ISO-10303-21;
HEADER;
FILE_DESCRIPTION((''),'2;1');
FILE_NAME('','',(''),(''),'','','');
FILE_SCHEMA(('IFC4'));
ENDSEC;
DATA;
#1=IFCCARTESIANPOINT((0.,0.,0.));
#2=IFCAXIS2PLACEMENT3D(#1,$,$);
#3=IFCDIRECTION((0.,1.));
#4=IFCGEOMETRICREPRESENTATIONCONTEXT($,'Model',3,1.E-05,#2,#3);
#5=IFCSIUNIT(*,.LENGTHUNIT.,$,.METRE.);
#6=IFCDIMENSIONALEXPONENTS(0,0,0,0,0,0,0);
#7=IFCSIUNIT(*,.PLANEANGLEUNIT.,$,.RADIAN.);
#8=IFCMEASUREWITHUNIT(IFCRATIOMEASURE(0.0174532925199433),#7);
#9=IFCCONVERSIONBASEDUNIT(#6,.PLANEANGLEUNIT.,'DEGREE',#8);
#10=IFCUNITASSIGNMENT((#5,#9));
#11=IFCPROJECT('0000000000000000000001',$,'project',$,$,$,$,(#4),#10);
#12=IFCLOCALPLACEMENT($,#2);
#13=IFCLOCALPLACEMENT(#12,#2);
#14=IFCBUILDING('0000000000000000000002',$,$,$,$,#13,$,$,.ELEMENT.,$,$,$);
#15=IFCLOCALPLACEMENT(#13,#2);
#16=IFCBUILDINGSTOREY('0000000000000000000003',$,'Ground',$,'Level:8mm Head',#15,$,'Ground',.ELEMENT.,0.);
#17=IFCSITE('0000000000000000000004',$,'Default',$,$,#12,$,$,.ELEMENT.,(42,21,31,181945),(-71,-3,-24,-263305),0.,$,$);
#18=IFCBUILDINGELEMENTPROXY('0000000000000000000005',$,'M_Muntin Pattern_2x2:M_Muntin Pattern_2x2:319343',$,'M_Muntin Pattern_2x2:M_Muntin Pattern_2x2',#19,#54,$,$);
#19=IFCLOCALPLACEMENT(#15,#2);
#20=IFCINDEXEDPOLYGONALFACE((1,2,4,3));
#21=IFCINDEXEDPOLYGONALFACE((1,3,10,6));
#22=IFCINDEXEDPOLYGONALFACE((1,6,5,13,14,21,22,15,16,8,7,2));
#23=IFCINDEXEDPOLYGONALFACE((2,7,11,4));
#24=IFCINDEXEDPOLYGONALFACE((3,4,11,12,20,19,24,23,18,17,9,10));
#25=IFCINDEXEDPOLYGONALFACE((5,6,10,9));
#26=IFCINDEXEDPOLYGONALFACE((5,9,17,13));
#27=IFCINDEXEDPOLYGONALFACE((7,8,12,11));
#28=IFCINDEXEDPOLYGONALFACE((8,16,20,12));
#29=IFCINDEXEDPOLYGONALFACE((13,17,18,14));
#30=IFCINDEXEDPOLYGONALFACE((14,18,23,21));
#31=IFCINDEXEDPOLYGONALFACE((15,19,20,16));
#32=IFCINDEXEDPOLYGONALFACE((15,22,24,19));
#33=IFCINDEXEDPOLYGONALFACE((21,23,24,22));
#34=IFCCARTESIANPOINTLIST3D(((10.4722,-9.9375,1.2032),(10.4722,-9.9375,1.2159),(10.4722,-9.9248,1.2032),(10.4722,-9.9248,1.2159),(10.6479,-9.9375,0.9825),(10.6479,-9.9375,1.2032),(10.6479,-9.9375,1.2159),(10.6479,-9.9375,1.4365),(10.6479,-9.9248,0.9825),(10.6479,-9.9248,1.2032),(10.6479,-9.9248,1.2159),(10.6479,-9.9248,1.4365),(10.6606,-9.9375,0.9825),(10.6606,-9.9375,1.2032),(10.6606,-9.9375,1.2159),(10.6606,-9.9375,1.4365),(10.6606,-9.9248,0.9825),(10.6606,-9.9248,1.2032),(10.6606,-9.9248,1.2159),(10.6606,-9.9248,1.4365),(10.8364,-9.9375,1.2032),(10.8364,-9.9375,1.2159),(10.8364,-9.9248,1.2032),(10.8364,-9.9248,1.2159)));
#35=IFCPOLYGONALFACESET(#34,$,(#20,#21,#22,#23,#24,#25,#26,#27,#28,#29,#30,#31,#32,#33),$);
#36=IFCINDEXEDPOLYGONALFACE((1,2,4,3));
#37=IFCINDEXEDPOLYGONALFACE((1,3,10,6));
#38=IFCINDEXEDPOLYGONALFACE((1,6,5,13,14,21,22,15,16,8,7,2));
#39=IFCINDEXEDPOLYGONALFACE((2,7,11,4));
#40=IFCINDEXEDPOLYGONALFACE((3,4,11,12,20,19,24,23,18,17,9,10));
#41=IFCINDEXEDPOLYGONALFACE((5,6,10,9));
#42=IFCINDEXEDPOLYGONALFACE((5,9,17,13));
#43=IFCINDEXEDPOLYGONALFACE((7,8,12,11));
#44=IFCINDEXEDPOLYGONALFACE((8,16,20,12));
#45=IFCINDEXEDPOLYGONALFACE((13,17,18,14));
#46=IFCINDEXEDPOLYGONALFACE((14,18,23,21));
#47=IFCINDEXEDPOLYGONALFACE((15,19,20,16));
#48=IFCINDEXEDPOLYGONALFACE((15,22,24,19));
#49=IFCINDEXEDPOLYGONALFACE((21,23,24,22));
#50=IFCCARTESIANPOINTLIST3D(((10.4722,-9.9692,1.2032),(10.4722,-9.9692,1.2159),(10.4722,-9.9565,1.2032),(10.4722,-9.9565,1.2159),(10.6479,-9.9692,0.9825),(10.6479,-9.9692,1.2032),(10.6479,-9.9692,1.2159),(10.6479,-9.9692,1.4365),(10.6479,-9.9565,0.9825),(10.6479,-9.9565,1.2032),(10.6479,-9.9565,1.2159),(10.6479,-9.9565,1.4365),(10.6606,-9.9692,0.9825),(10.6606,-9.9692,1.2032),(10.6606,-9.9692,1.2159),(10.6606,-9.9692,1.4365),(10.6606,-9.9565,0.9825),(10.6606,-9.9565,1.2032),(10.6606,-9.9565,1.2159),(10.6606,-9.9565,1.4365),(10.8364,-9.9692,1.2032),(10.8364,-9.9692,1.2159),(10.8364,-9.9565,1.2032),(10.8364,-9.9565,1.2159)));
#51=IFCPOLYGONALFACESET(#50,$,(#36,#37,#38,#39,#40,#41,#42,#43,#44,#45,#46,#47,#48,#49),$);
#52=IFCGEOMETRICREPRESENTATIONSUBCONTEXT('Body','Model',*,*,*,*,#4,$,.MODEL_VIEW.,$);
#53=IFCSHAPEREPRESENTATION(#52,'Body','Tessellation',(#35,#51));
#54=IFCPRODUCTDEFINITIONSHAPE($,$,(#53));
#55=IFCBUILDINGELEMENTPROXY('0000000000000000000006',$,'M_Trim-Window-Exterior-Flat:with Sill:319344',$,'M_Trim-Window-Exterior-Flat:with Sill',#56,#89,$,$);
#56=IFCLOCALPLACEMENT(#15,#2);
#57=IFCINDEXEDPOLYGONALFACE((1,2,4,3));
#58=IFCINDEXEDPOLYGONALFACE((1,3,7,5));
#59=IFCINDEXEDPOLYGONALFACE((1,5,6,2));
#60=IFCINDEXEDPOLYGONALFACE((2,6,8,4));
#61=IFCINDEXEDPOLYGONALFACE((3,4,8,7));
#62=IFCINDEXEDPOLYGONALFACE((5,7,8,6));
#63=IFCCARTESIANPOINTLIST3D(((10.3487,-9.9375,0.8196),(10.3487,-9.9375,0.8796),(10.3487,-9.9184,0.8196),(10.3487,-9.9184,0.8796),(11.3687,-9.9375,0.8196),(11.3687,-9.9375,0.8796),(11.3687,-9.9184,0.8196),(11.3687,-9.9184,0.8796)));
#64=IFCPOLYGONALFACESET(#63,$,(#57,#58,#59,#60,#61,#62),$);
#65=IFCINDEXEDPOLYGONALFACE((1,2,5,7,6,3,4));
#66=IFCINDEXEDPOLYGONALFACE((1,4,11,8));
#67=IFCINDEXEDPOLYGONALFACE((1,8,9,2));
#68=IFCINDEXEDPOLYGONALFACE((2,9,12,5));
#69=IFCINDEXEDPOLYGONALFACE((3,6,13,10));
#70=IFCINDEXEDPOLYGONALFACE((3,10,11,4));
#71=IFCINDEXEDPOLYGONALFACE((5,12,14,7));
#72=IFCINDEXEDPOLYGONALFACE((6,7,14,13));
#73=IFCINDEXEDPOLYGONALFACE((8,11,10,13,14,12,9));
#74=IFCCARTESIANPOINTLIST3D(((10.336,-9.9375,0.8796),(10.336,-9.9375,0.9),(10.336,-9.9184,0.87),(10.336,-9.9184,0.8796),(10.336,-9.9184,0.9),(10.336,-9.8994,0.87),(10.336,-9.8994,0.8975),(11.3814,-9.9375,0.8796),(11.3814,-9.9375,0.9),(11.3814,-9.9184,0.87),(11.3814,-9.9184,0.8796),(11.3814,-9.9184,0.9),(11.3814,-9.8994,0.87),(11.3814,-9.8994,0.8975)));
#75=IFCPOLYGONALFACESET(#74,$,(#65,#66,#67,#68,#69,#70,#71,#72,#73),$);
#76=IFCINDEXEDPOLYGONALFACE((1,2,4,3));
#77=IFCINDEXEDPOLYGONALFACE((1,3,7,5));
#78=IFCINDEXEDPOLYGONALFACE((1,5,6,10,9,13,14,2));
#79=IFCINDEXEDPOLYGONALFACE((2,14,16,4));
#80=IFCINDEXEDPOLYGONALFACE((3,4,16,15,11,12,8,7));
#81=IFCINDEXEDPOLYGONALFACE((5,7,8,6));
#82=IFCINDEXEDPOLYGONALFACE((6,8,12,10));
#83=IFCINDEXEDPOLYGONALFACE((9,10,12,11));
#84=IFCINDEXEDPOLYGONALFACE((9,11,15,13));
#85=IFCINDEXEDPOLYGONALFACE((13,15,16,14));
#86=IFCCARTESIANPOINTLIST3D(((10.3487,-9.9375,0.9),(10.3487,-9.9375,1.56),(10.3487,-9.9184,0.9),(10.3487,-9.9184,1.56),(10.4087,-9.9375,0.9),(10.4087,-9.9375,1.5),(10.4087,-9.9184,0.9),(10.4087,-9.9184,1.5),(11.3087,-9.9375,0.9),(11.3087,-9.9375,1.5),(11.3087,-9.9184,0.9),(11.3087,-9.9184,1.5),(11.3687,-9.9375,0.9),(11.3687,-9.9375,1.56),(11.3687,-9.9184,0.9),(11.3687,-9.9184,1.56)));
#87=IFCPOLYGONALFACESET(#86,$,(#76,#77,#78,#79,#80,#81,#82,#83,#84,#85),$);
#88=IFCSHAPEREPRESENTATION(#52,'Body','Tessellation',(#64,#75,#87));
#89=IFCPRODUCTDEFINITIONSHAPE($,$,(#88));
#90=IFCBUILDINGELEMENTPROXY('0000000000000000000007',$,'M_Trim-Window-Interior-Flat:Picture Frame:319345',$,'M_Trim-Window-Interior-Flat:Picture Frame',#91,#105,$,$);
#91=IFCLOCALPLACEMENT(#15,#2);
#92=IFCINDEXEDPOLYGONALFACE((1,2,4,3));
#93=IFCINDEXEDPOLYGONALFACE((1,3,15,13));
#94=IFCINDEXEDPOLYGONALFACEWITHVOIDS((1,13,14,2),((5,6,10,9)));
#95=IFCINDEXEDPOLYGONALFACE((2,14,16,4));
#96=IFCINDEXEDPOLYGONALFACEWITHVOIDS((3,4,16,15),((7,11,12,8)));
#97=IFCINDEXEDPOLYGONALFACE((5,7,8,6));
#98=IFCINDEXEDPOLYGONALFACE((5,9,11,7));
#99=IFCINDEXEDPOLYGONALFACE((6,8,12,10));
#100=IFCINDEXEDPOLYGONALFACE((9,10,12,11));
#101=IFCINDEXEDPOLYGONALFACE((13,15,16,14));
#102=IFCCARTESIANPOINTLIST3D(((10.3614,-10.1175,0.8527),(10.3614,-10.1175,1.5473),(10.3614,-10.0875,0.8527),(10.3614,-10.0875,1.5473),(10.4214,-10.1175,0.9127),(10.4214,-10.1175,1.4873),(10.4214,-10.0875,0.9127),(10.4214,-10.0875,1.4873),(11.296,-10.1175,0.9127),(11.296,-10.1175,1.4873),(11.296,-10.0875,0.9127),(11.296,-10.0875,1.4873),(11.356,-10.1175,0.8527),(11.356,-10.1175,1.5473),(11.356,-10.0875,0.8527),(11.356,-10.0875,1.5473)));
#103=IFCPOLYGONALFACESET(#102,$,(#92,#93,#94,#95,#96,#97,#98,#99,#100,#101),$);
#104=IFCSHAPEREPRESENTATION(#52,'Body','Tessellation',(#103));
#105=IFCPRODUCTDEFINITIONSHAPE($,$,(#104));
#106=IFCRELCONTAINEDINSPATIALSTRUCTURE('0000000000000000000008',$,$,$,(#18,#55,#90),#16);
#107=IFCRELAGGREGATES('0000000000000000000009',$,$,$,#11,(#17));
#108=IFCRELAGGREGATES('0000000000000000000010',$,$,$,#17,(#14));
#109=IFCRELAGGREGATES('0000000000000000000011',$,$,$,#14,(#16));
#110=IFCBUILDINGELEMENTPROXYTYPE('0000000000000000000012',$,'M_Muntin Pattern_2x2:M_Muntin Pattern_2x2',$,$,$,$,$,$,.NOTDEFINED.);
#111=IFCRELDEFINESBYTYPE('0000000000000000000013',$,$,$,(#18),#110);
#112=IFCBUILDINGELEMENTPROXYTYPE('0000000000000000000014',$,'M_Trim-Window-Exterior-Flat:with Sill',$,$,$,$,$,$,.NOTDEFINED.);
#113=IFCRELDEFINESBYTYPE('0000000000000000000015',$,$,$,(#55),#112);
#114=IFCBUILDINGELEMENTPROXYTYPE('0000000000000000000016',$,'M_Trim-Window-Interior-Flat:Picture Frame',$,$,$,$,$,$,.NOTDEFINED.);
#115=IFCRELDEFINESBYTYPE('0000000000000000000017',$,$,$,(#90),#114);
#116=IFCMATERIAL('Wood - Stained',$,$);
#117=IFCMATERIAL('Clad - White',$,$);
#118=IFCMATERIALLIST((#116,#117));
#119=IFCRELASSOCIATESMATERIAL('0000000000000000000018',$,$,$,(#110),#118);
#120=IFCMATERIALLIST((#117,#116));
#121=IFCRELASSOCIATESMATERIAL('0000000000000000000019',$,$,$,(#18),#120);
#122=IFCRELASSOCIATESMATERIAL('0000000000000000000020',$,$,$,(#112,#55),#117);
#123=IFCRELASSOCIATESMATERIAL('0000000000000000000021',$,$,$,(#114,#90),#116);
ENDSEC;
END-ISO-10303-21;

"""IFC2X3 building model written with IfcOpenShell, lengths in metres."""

from ifc_helpers import new_model, entity, si_unit, converted_unit, direction, frame, frame_2d, origin, place, context, subcontext, project, spatial, polyline, rectangle, outline, extrude, source, transform, mapped, material, material_list, type_object, type_shapes, element, save


model = new_model("IFC2X3")

# Units and contexts
model_context = context("Model", 3, precision=1e-05, world=origin(), true_north=direction((0.0, 1.0)))
body_context = subcontext(model_context, "Body", "Model", "MODEL_VIEW")
ifc_project = project(units=[si_unit("LENGTHUNIT", "METRE"), converted_unit("PLANEANGLEUNIT", "DEGREE", entity("IfcRatioMeasure", 0.0174532925199433), si_unit("PLANEANGLEUNIT", "RADIAN"), dimensions=[0, 0, 0, 0, 0, 0, 0])], contexts=[model_context])

# Site, building, storey
site_placement = place(None, origin())
site = spatial("IfcSite", under=ifc_project, at=site_placement, Name="Default", CompositionType="ELEMENT", RefLatitude=(42, 21, 31, 181945), RefLongitude=(-71, -3, -24, -263305), RefElevation=0.0)
building_placement = place(site_placement, origin())
building = spatial("IfcBuilding", under=site, at=building_placement, CompositionType="ELEMENT")
storey_placement = place(building_placement, origin())
storey = spatial("IfcBuildingStorey", under=building, at=storey_placement, Name="Ground", ObjectType="Level:8mm Head", LongName="Ground", CompositionType="ELEMENT", Elevation=0.0)

# Building element proxies
ifc_material_1 = material(Name="Clad - White")
ifc_material_2 = material(Name="Wood - Stained")
ifc_material_list_1 = material_list([ifc_material_2, ifc_material_1])
building_element_proxy_type_1 = type_object("IfcBuildingElementProxyType", Name="M_Muntin Pattern_2x2:M_Muntin Pattern_2x2", PredefinedType="NOTDEFINED", material=ifc_material_list_1)
shared_shape_1 = source(origin(), body_context, "Body", "SweptSolid", [
    extrude(outline(polyline([(0.0064, -0.0064), (0.227, -0.0064), (0.227, 0.0063), (0.0064, 0.0063), (0.0064, 0.1821), (-0.0063, 0.1821), (-0.0063, 0.0063), (-0.227, 0.0063), (-0.227, -0.0064), (-0.0063, -0.0064), (-0.0063, -0.1821), (0.0064, -0.1821), (0.0064, -0.0064)])), frame((0.0, 0.0095, 0.227), z_axis=(0.0, 1.0, 0.0), x_axis=(0.0, 0.0, 1.0)), (0.0, 0.0, 1.0), 0.0127),
    extrude(outline(polyline([(0.0064, -0.0064), (0.227, -0.0064), (0.227, 0.0063), (0.0064, 0.0063), (0.0064, 0.1821), (-0.0063, 0.1821), (-0.0063, 0.0063), (-0.227, 0.0063), (-0.227, -0.0064), (-0.0063, -0.0064), (-0.0063, -0.1821), (0.0064, -0.1821), (0.0064, -0.0064)])), frame((0.0, -0.0222, 0.227), z_axis=(0.0, 1.0, 0.0), x_axis=(0.0, 0.0, 1.0)), (0.0, 0.0, 1.0), 0.0127),
])
type_shapes(building_element_proxy_type_1, [shared_shape_1])
ifc_material_list_2 = material_list([ifc_material_1, ifc_material_2])
proxy_1_placement = place(storey_placement, frame((10.6543, -9.947, 0.9825)))
element("IfcBuildingElementProxy", 1, at=proxy_1_placement, inside=storey, type_object=building_element_proxy_type_1, material=ifc_material_list_2, Name="M_Muntin Pattern_2x2:M_Muntin Pattern_2x2:319343", ObjectType="M_Muntin Pattern_2x2:M_Muntin Pattern_2x2", context=body_context, shape_type="MappedRepresentation", body=[
    mapped(shared_shape_1, transform((0.0, 0.0, 0.0), scale=1.0)),
])
building_element_proxy_type_2 = type_object("IfcBuildingElementProxyType", Name="M_Trim-Window-Exterior-Flat:with Sill", PredefinedType="NOTDEFINED", material=ifc_material_1)
shared_shape_2 = source(origin(), body_context, "Body", "SweptSolid", [
    extrude(rectangle(XDim=1.02, YDim=0.06, at=frame_2d((0.0, 0.0), x_axis=(1.0, 0.0))), frame((0.0, -0.6504, 0.0), z_axis=(0.0, 0.0, 1.0), x_axis=(-1.0, 0.0, 0.0)), (0.0, 0.0, 1.0), 0.0191),
    extrude(outline(polyline([(-0.019, -0.0152), (0.0, -0.0152), (0.0, -0.0057), (0.019, -0.0057), (0.019, 0.0148), (0.0, 0.0148), (-0.019, 0.0123), (-0.019, -0.0152)])), frame((-0.5227, -0.6148, 0.019), z_axis=(1.0, 0.0, 0.0), x_axis=(0.0, 0.0, -1.0)), (0.0, 0.0, 1.0), 1.0454),
    extrude(outline(polyline([(-0.345, -0.51), (0.315, -0.51), (0.315, -0.45), (-0.285, -0.45), (-0.285, 0.45), (0.315, 0.45), (0.315, 0.51), (-0.345, 0.51), (-0.345, -0.51)])), frame((0.0, -0.285, 0.0), z_axis=(0.0, 0.0, 1.0), x_axis=(0.0, -1.0, 0.0)), (0.0, 0.0, 1.0), 0.0191),
])
type_shapes(building_element_proxy_type_2, [shared_shape_2])
proxy_2_placement = place(storey_placement, frame((10.8587, -9.9375, 1.5), z_axis=(0.0, 1.0, 0.0), x_axis=(-1.0, 0.0, 0.0)))
element("IfcBuildingElementProxy", 2, at=proxy_2_placement, inside=storey, type_object=building_element_proxy_type_2, material=ifc_material_1, Name="M_Trim-Window-Exterior-Flat:with Sill:319344", ObjectType="M_Trim-Window-Exterior-Flat:with Sill", context=body_context, shape_type="MappedRepresentation", body=[
    mapped(shared_shape_2, transform((0.0, 0.0, 0.0), scale=1.0)),
])
building_element_proxy_type_3 = type_object("IfcBuildingElementProxyType", Name="M_Trim-Window-Interior-Flat:Picture Frame", PredefinedType="NOTDEFINED", material=ifc_material_2)
shared_shape_3 = source(origin(), body_context, "Body", "SweptSolid", [
    extrude(outline(polyline([(-0.4973, -0.3473), (0.4973, -0.3473), (0.4973, 0.3473), (-0.4973, 0.3473), (-0.4973, -0.3473)]), holes=[polyline([(-0.4373, -0.2873), (-0.4373, 0.2873), (0.4373, 0.2873), (0.4373, -0.2873), (-0.4373, -0.2873)])]), frame((0.0, -0.3, 0.0), z_axis=(0.0, 0.0, 1.0), x_axis=(-1.0, 0.0, 0.0)), (0.0, 0.0, 1.0), 0.03),
])
type_shapes(building_element_proxy_type_3, [shared_shape_3])
proxy_3_placement = place(storey_placement, frame((10.8587, -10.0875, 1.5), z_axis=(0.0, -1.0, 0.0), x_axis=(1.0, 0.0, 0.0)))
element("IfcBuildingElementProxy", 3, at=proxy_3_placement, inside=storey, type_object=building_element_proxy_type_3, material=ifc_material_2, Name="M_Trim-Window-Interior-Flat:Picture Frame:319345", ObjectType="M_Trim-Window-Interior-Flat:Picture Frame", context=body_context, shape_type="MappedRepresentation", body=[
    mapped(shared_shape_3, transform((0.0, 0.0, 0.0), scale=1.0)),
])

save(model, "model.ifc")
